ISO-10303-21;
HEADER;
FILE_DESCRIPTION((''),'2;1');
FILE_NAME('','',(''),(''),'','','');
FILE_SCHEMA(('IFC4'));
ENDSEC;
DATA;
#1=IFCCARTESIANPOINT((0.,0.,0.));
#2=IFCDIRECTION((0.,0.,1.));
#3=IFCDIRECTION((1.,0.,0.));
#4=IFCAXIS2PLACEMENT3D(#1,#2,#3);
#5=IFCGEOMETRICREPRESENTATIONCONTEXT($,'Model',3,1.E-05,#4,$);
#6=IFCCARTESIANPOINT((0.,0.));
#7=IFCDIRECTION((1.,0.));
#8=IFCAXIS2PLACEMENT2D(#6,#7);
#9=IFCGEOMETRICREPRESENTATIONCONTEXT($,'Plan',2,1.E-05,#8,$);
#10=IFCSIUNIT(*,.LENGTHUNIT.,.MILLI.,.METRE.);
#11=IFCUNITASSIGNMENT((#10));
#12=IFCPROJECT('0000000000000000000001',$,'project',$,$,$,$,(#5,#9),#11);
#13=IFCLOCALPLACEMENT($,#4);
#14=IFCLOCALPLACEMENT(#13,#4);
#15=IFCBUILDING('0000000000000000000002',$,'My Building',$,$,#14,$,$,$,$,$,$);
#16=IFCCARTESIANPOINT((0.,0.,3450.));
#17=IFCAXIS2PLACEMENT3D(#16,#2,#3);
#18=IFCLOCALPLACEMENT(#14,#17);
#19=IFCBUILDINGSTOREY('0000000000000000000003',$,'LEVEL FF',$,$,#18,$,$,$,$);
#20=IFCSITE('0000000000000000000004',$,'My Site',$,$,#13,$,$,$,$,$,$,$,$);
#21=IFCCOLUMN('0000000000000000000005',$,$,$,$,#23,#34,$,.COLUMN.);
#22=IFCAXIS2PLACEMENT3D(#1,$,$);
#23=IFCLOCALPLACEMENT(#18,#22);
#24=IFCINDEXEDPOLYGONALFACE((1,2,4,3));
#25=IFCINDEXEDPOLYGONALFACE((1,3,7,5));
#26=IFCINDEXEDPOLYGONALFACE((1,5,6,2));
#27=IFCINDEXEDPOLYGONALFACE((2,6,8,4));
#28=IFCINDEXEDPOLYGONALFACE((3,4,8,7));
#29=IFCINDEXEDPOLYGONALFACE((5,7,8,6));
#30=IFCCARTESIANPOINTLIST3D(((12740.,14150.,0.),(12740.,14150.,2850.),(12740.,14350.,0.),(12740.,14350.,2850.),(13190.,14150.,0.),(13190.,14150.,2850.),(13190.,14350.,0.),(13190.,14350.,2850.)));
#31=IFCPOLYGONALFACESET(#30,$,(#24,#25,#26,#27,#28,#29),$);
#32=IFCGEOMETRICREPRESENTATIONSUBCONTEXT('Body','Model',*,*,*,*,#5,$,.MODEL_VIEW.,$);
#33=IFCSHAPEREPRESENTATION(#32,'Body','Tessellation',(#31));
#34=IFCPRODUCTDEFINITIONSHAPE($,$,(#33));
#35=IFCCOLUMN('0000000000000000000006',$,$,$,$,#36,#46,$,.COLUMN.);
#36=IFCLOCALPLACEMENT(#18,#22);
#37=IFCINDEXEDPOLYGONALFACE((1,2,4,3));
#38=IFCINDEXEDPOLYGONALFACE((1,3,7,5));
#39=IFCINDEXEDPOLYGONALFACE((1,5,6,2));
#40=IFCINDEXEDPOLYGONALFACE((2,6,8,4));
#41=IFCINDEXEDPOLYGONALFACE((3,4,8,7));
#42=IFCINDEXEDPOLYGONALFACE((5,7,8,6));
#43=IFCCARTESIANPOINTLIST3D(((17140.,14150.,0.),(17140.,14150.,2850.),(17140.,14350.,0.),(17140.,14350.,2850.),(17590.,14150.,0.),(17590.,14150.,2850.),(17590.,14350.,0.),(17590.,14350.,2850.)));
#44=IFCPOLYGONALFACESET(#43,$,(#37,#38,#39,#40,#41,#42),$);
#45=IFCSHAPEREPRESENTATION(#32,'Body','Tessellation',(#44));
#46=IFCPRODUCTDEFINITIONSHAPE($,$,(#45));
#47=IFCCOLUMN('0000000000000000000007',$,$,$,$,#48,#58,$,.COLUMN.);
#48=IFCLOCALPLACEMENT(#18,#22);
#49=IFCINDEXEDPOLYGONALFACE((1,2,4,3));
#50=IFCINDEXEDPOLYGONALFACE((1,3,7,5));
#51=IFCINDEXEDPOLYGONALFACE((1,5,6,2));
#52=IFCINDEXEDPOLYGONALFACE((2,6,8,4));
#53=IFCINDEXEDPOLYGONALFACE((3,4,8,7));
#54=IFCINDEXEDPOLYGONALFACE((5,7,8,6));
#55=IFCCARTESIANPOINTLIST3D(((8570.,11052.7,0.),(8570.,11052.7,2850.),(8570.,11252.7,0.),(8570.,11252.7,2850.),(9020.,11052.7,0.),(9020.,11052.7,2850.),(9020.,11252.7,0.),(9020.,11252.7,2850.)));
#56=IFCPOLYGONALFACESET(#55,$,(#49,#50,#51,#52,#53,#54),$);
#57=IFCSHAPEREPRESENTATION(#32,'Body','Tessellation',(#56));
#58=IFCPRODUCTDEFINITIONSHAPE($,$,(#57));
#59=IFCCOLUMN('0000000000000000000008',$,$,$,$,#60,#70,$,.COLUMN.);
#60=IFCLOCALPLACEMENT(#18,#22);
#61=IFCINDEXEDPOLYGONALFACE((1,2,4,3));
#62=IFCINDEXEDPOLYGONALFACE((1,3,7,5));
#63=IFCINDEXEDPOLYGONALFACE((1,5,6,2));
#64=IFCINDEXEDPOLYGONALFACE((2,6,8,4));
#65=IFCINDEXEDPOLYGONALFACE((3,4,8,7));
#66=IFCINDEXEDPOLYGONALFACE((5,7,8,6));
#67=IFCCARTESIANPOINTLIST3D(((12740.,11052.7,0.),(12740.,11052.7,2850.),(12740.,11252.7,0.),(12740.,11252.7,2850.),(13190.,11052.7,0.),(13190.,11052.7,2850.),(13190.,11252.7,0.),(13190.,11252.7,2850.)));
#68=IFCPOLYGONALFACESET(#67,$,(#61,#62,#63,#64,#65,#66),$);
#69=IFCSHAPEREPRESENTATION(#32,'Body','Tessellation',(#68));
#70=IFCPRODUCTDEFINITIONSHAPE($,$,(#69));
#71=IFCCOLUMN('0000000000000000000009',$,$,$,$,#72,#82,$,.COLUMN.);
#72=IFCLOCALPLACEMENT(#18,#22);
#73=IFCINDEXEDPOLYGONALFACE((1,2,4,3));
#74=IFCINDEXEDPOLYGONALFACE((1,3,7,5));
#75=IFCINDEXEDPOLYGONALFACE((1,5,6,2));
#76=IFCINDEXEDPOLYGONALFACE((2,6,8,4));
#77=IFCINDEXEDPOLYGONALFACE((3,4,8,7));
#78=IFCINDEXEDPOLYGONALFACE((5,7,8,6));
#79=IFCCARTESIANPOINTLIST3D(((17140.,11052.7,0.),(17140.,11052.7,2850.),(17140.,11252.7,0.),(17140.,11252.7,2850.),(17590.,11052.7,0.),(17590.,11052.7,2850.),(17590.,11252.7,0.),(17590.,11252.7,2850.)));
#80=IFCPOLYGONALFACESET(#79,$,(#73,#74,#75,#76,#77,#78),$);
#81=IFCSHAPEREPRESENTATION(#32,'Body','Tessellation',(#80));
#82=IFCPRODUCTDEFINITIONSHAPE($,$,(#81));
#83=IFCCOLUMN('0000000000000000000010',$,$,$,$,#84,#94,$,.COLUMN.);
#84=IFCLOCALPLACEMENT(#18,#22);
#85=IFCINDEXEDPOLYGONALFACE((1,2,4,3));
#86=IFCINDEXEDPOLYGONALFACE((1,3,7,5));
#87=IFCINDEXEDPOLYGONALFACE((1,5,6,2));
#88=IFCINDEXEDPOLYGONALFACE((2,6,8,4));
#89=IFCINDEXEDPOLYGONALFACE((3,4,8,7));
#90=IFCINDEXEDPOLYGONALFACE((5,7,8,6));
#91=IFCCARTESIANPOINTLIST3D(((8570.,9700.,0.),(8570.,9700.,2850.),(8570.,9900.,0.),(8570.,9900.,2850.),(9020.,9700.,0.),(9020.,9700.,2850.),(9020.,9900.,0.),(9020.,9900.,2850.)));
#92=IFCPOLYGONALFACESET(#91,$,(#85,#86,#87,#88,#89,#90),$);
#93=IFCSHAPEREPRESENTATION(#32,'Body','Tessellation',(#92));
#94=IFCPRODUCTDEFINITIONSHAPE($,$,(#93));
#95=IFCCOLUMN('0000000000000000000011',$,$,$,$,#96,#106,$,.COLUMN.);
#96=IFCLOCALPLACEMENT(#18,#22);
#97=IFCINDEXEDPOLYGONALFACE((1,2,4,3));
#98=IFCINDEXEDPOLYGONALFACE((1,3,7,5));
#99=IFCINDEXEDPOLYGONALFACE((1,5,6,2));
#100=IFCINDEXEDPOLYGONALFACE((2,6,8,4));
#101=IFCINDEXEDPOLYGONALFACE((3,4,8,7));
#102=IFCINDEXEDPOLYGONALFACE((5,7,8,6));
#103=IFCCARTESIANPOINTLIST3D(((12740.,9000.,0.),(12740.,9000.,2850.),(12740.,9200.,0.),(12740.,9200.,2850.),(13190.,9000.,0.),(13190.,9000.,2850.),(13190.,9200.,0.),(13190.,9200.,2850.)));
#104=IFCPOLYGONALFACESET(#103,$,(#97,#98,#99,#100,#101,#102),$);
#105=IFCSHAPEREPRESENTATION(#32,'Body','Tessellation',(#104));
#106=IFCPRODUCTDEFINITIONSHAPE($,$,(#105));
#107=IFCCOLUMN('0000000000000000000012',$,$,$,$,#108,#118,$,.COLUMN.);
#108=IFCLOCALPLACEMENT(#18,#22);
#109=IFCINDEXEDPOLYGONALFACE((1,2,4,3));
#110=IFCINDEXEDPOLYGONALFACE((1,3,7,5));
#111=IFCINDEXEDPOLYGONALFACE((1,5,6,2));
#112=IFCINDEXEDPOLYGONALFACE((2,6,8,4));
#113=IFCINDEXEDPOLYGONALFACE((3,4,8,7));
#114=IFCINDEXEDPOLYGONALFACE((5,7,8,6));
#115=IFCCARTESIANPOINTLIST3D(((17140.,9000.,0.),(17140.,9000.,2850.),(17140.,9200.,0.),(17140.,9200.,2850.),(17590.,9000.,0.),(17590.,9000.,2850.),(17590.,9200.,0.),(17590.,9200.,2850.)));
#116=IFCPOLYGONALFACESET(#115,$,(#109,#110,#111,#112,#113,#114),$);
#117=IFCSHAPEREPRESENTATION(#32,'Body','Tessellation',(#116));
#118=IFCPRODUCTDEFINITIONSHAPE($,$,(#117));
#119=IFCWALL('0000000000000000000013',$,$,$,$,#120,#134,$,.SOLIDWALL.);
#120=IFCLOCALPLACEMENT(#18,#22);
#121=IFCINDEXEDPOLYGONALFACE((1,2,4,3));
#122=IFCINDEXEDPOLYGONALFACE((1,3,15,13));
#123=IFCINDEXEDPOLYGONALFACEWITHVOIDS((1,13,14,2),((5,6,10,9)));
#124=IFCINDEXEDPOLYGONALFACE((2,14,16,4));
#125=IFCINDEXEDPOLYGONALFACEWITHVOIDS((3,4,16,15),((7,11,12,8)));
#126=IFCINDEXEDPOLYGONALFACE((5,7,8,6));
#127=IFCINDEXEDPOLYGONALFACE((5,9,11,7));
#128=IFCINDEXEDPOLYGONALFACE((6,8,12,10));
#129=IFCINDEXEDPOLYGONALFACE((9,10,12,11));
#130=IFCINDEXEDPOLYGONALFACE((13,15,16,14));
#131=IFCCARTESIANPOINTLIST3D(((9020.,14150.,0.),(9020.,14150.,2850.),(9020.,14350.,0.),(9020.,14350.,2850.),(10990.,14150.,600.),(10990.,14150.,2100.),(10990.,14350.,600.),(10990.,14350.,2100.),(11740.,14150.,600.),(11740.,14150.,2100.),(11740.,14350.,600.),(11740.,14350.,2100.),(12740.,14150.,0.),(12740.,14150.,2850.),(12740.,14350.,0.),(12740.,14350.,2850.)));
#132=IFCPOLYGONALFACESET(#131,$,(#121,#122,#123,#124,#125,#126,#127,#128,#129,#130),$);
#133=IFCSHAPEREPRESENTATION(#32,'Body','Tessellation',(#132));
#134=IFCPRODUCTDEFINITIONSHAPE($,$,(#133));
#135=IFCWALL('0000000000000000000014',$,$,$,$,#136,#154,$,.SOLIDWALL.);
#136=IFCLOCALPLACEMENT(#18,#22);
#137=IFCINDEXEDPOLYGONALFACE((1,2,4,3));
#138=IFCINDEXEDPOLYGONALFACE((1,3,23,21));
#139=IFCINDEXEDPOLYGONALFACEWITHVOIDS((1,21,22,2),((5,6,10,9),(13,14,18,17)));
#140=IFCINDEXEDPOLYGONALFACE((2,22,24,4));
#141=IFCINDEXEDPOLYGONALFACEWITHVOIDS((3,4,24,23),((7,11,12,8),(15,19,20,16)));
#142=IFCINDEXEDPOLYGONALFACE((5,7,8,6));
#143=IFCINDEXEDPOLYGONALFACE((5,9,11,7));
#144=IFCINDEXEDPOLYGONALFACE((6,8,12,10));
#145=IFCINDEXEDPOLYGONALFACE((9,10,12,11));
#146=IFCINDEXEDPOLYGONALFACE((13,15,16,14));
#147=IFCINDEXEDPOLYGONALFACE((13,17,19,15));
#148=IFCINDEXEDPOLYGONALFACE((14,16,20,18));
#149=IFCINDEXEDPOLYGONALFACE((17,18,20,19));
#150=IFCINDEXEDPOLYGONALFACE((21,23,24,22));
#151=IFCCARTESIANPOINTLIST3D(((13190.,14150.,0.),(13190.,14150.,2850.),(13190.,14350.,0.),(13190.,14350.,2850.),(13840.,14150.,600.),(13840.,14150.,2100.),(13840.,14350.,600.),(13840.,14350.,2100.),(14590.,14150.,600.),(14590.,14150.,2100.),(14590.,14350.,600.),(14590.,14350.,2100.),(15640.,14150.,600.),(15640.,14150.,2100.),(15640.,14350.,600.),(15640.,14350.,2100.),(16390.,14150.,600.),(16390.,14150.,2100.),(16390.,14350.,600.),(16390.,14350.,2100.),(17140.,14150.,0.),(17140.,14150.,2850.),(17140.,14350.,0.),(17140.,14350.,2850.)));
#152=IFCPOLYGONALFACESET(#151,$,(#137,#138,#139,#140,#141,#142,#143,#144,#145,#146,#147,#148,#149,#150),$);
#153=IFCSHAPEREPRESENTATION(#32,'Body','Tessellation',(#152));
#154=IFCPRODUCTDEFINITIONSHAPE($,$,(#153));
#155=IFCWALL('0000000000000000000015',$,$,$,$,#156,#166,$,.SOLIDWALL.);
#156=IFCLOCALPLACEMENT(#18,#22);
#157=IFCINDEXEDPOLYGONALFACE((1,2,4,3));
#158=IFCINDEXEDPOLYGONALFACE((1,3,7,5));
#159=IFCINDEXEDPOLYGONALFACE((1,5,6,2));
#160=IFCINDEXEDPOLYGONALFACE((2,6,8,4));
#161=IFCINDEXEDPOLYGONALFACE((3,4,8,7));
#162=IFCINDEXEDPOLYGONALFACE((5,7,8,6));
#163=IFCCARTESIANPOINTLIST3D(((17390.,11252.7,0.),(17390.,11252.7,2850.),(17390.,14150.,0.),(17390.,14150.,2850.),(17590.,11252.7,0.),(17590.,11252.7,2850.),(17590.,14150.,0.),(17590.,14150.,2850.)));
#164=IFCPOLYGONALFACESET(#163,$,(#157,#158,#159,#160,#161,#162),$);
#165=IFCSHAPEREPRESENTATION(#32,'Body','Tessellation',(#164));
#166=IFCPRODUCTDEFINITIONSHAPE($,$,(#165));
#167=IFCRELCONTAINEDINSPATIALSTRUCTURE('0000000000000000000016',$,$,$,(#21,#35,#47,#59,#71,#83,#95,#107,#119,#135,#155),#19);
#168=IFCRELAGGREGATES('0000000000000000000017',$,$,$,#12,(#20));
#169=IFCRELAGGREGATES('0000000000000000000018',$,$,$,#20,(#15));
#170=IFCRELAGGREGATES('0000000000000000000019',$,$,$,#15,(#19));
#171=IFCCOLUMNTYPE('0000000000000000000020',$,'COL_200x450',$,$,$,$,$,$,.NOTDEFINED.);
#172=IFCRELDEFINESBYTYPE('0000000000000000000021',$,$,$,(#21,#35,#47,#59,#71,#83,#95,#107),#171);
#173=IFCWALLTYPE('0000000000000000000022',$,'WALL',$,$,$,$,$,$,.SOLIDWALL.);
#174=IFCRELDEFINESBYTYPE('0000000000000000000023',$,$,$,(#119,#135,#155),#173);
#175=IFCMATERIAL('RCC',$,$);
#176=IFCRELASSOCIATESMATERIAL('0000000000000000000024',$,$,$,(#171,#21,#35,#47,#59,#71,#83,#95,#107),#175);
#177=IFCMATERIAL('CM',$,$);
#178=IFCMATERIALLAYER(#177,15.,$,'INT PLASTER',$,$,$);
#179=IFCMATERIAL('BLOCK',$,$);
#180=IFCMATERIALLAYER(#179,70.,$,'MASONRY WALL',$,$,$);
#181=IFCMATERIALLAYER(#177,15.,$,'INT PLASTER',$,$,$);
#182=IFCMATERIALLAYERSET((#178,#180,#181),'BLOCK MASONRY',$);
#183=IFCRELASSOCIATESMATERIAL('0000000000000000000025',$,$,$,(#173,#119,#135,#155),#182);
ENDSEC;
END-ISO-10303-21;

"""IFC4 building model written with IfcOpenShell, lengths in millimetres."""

from ifc_helpers import new_model, si_unit, frame, origin_with_axes, origin_2d_with_axis, place, context, subcontext, project, spatial, indexed_curve, rectangle, outline, extrude, material, layer, layer_set, layer_usage, material_profile, profile_set, profile_usage, type_object, element, save


model = new_model("IFC4")

# Units and contexts
model_context = context("Model", 3, precision=1e-05, world=origin_with_axes())
plan_context = context("Plan", 2, precision=1e-05, world=origin_2d_with_axis())
body_context = subcontext(model_context, "Body", "Model", "MODEL_VIEW")
ifc_project = project(units=[si_unit("LENGTHUNIT", "METRE", prefix="MILLI")], contexts=[model_context, plan_context])

# Site, building, storey
site_placement = place(None, origin_with_axes())
site = spatial("IfcSite", under=ifc_project, at=site_placement, Name="My Site")
building_placement = place(site_placement, origin_with_axes())
building = spatial("IfcBuilding", under=site, at=building_placement, Name="My Building")
storey_placement = place(building_placement, frame((0.0, 0.0, 3450.0), z_axis=(0.0, 0.0, 1.0), x_axis=(1.0, 0.0, 0.0)))
storey = spatial("IfcBuildingStorey", under=building, at=storey_placement, Name="LEVEL FF")

# Columns
ifc_material_1 = material(Name="RCC")
ifc_material_profile = material_profile(ifc_material_1, rectangle(XDim=200.0, YDim=450.0))
ifc_profile_set = profile_set([ifc_material_profile], Name="COL_200x450")
ifc_profile_usage_1 = profile_usage(ifc_profile_set)
column_type = type_object("IfcColumnType", Name="COL_200x450", PredefinedType="NOTDEFINED", material=ifc_profile_set)
column_1_placement = place(storey_placement, frame((12965.0, 14250.0, 0.0), z_axis=(0.0, 0.0, 1.0), x_axis=(0.0, -1.0, 0.0)))
element("IfcColumn", 1, at=column_1_placement, inside=storey, type_object=column_type, material=ifc_profile_usage_1, PredefinedType="COLUMN", context=body_context, shape_type="SweptSolid", body=[
    extrude(rectangle(XDim=200.0, YDim=450.0), origin_with_axes(), (0.0, 0.0, 1.0), 2850.0),
])
ifc_profile_usage_2 = profile_usage(ifc_profile_set)
column_2_placement = place(storey_placement, frame((17365.0, 14250.0, 0.0), z_axis=(0.0, 0.0, 1.0), x_axis=(0.0, -1.0, 0.0)))
element("IfcColumn", 2, at=column_2_placement, inside=storey, type_object=column_type, material=ifc_profile_usage_2, PredefinedType="COLUMN", context=body_context, shape_type="SweptSolid", body=[
    extrude(rectangle(XDim=200.0, YDim=450.0), origin_with_axes(), (0.0, 0.0, 1.0), 2850.0),
])
ifc_profile_usage_3 = profile_usage(ifc_profile_set)
column_3_placement = place(storey_placement, frame((8795.0, 11152.7, 0.0), z_axis=(0.0, 0.0, 1.0), x_axis=(0.0, -1.0, 0.0)))
element("IfcColumn", 3, at=column_3_placement, inside=storey, type_object=column_type, material=ifc_profile_usage_3, PredefinedType="COLUMN", context=body_context, shape_type="SweptSolid", body=[
    extrude(rectangle(XDim=200.0, YDim=450.0), origin_with_axes(), (0.0, 0.0, 1.0), 2850.0),
])
ifc_profile_usage_4 = profile_usage(ifc_profile_set)
column_4_placement = place(storey_placement, frame((12965.0, 11152.7, 0.0), z_axis=(0.0, 0.0, 1.0), x_axis=(0.0, -1.0, 0.0)))
element("IfcColumn", 4, at=column_4_placement, inside=storey, type_object=column_type, material=ifc_profile_usage_4, PredefinedType="COLUMN", context=body_context, shape_type="SweptSolid", body=[
    extrude(rectangle(XDim=200.0, YDim=450.0), origin_with_axes(), (0.0, 0.0, 1.0), 2850.0),
])
ifc_profile_usage_5 = profile_usage(ifc_profile_set)
column_5_placement = place(storey_placement, frame((17365.0, 11152.7, 0.0), z_axis=(0.0, 0.0, 1.0), x_axis=(0.0, -1.0, 0.0)))
element("IfcColumn", 5, at=column_5_placement, inside=storey, type_object=column_type, material=ifc_profile_usage_5, PredefinedType="COLUMN", context=body_context, shape_type="SweptSolid", body=[
    extrude(rectangle(XDim=200.0, YDim=450.0), origin_with_axes(), (0.0, 0.0, 1.0), 2850.0),
])
ifc_profile_usage_6 = profile_usage(ifc_profile_set)
column_6_placement = place(storey_placement, frame((8795.0, 9800.0, 0.0), z_axis=(0.0, 0.0, 1.0), x_axis=(0.0, -1.0, 0.0)))
element("IfcColumn", 6, at=column_6_placement, inside=storey, type_object=column_type, material=ifc_profile_usage_6, PredefinedType="COLUMN", context=body_context, shape_type="SweptSolid", body=[
    extrude(rectangle(XDim=200.0, YDim=450.0), origin_with_axes(), (0.0, 0.0, 1.0), 2850.0),
])
ifc_profile_usage_7 = profile_usage(ifc_profile_set)
column_7_placement = place(storey_placement, frame((12965.0, 9100.0, 0.0), z_axis=(0.0, 0.0, 1.0), x_axis=(0.0, -1.0, 0.0)))
element("IfcColumn", 7, at=column_7_placement, inside=storey, type_object=column_type, material=ifc_profile_usage_7, PredefinedType="COLUMN", context=body_context, shape_type="SweptSolid", body=[
    extrude(rectangle(XDim=200.0, YDim=450.0), origin_with_axes(), (0.0, 0.0, 1.0), 2850.0),
])
ifc_profile_usage_8 = profile_usage(ifc_profile_set)
column_8_placement = place(storey_placement, frame((17365.0, 9100.0, 0.0), z_axis=(0.0, 0.0, 1.0), x_axis=(0.0, -1.0, 0.0)))
element("IfcColumn", 8, at=column_8_placement, inside=storey, type_object=column_type, material=ifc_profile_usage_8, PredefinedType="COLUMN", context=body_context, shape_type="SweptSolid", body=[
    extrude(rectangle(XDim=200.0, YDim=450.0), origin_with_axes(), (0.0, 0.0, 1.0), 2850.0),
])

# Wall, opening
ifc_material_2 = material(Name="CM")
ifc_layer_1 = layer(ifc_material_2, 15.0, Name="INT PLASTER")
ifc_material_3 = material(Name="BLOCK")
ifc_layer_2 = layer(ifc_material_3, 70.0, Name="MASONRY WALL")
ifc_layer_3 = layer(ifc_material_2, 15.0, Name="INT PLASTER")
ifc_layer_set = layer_set([ifc_layer_1, ifc_layer_2, ifc_layer_3], Name="BLOCK MASONRY")
ifc_layer_usage_1 = layer_usage(ifc_layer_set, "AXIS2", "POSITIVE", 0.0)
wall_type = type_object("IfcWallType", Name="WALL", PredefinedType="SOLIDWALL", material=ifc_layer_set)
wall_1_placement = place(storey_placement, frame((9020.0, 14350.0, 0.0), z_axis=(0.0, 0.0, 1.0), x_axis=(0.0, -1.0, 0.0)))
wall_1 = element("IfcWall", 9, at=wall_1_placement, inside=storey, type_object=wall_type, material=ifc_layer_usage_1, PredefinedType="SOLIDWALL", context=body_context, shape_type="SweptSolid", body=[
    extrude(outline(indexed_curve([(0.0, 0.0), (0.0, 3720.0), (200.0, 3720.0), (200.0, 0.0), (0.0, 0.0)], self_intersect=False)), origin_with_axes(), (0.0, 0.0, 1.0), 2850.0),
])
opening_1_placement = place(wall_1_placement, frame((200.0, 1970.0, 600.0), z_axis=(0.0, 0.0, 1.0), x_axis=(0.0, 1.0, 0.0)))
element("IfcOpeningElement", 10, at=opening_1_placement, cuts=wall_1, PredefinedType="OPENING", context=body_context, shape_type="SweptSolid", body=[
    extrude(outline(indexed_curve([(0.0, 0.0), (0.0, 400.0), (750.0, 400.0), (750.0, 0.0), (0.0, 0.0)], self_intersect=False)), frame((0.0, -100.0, 0.0), z_axis=(0.0, 0.0, 1.0), x_axis=(1.0, 0.0, 0.0)), (0.0, 0.0, 1.0), 1500.0),
])

# Wall, openings
ifc_layer_usage_2 = layer_usage(ifc_layer_set, "AXIS2", "POSITIVE", 0.0)
wall_2_placement = place(storey_placement, frame((13190.0, 14350.0, 0.0), z_axis=(0.0, 0.0, 1.0), x_axis=(0.0, -1.0, 0.0)))
wall_2 = element("IfcWall", 11, at=wall_2_placement, inside=storey, type_object=wall_type, material=ifc_layer_usage_2, PredefinedType="SOLIDWALL", context=body_context, shape_type="SweptSolid", body=[
    extrude(outline(indexed_curve([(0.0, 0.0), (0.0, 3950.0), (200.0, 3950.0), (200.0, 0.0), (0.0, 0.0)], self_intersect=False)), origin_with_axes(), (0.0, 0.0, 1.0), 2850.0),
])
opening_2_placement = place(wall_2_placement, frame((200.0, 650.0, 600.0), z_axis=(0.0, 0.0, 1.0), x_axis=(0.0, 1.0, 0.0)))
element("IfcOpeningElement", 12, at=opening_2_placement, cuts=wall_2, PredefinedType="OPENING", context=body_context, shape_type="SweptSolid", body=[
    extrude(outline(indexed_curve([(0.0, 0.0), (0.0, 400.0), (750.0, 400.0), (750.0, 0.0), (0.0, 0.0)], self_intersect=False)), frame((0.0, -100.0, 0.0), z_axis=(0.0, 0.0, 1.0), x_axis=(1.0, 0.0, 0.0)), (0.0, 0.0, 1.0), 1500.0),
])
opening_3_placement = place(wall_2_placement, frame((200.0, 2450.0, 600.0), z_axis=(0.0, 0.0, 1.0), x_axis=(0.0, 1.0, 0.0)))
element("IfcOpeningElement", 13, at=opening_3_placement, cuts=wall_2, PredefinedType="OPENING", context=body_context, shape_type="SweptSolid", body=[
    extrude(outline(indexed_curve([(0.0, 0.0), (0.0, 400.0), (750.0, 400.0), (750.0, 0.0), (0.0, 0.0)], self_intersect=False)), frame((0.0, -100.0, 0.0), z_axis=(0.0, 0.0, 1.0), x_axis=(1.0, 0.0, 0.0)), (0.0, 0.0, 1.0), 1500.0),
])

# Wall
ifc_layer_usage_3 = layer_usage(ifc_layer_set, "AXIS2", "POSITIVE", 0.0)
wall_3_placement = place(storey_placement, frame((17590.0, 11252.7, 0.0), z_axis=(0.0, 0.0, 1.0), x_axis=(0.0, 1.0, 0.0)))
element("IfcWall", 14, at=wall_3_placement, inside=storey, type_object=wall_type, material=ifc_layer_usage_3, PredefinedType="SOLIDWALL", context=body_context, shape_type="SweptSolid", body=[
    extrude(outline(indexed_curve([(0.0, 0.0), (0.0, 200.0), (2897.3, 200.0), (2897.3, 0.0), (0.0, 0.0)], self_intersect=False)), origin_with_axes(), (0.0, 0.0, 1.0), 2850.0),
])

save(model, "model.ifc")
